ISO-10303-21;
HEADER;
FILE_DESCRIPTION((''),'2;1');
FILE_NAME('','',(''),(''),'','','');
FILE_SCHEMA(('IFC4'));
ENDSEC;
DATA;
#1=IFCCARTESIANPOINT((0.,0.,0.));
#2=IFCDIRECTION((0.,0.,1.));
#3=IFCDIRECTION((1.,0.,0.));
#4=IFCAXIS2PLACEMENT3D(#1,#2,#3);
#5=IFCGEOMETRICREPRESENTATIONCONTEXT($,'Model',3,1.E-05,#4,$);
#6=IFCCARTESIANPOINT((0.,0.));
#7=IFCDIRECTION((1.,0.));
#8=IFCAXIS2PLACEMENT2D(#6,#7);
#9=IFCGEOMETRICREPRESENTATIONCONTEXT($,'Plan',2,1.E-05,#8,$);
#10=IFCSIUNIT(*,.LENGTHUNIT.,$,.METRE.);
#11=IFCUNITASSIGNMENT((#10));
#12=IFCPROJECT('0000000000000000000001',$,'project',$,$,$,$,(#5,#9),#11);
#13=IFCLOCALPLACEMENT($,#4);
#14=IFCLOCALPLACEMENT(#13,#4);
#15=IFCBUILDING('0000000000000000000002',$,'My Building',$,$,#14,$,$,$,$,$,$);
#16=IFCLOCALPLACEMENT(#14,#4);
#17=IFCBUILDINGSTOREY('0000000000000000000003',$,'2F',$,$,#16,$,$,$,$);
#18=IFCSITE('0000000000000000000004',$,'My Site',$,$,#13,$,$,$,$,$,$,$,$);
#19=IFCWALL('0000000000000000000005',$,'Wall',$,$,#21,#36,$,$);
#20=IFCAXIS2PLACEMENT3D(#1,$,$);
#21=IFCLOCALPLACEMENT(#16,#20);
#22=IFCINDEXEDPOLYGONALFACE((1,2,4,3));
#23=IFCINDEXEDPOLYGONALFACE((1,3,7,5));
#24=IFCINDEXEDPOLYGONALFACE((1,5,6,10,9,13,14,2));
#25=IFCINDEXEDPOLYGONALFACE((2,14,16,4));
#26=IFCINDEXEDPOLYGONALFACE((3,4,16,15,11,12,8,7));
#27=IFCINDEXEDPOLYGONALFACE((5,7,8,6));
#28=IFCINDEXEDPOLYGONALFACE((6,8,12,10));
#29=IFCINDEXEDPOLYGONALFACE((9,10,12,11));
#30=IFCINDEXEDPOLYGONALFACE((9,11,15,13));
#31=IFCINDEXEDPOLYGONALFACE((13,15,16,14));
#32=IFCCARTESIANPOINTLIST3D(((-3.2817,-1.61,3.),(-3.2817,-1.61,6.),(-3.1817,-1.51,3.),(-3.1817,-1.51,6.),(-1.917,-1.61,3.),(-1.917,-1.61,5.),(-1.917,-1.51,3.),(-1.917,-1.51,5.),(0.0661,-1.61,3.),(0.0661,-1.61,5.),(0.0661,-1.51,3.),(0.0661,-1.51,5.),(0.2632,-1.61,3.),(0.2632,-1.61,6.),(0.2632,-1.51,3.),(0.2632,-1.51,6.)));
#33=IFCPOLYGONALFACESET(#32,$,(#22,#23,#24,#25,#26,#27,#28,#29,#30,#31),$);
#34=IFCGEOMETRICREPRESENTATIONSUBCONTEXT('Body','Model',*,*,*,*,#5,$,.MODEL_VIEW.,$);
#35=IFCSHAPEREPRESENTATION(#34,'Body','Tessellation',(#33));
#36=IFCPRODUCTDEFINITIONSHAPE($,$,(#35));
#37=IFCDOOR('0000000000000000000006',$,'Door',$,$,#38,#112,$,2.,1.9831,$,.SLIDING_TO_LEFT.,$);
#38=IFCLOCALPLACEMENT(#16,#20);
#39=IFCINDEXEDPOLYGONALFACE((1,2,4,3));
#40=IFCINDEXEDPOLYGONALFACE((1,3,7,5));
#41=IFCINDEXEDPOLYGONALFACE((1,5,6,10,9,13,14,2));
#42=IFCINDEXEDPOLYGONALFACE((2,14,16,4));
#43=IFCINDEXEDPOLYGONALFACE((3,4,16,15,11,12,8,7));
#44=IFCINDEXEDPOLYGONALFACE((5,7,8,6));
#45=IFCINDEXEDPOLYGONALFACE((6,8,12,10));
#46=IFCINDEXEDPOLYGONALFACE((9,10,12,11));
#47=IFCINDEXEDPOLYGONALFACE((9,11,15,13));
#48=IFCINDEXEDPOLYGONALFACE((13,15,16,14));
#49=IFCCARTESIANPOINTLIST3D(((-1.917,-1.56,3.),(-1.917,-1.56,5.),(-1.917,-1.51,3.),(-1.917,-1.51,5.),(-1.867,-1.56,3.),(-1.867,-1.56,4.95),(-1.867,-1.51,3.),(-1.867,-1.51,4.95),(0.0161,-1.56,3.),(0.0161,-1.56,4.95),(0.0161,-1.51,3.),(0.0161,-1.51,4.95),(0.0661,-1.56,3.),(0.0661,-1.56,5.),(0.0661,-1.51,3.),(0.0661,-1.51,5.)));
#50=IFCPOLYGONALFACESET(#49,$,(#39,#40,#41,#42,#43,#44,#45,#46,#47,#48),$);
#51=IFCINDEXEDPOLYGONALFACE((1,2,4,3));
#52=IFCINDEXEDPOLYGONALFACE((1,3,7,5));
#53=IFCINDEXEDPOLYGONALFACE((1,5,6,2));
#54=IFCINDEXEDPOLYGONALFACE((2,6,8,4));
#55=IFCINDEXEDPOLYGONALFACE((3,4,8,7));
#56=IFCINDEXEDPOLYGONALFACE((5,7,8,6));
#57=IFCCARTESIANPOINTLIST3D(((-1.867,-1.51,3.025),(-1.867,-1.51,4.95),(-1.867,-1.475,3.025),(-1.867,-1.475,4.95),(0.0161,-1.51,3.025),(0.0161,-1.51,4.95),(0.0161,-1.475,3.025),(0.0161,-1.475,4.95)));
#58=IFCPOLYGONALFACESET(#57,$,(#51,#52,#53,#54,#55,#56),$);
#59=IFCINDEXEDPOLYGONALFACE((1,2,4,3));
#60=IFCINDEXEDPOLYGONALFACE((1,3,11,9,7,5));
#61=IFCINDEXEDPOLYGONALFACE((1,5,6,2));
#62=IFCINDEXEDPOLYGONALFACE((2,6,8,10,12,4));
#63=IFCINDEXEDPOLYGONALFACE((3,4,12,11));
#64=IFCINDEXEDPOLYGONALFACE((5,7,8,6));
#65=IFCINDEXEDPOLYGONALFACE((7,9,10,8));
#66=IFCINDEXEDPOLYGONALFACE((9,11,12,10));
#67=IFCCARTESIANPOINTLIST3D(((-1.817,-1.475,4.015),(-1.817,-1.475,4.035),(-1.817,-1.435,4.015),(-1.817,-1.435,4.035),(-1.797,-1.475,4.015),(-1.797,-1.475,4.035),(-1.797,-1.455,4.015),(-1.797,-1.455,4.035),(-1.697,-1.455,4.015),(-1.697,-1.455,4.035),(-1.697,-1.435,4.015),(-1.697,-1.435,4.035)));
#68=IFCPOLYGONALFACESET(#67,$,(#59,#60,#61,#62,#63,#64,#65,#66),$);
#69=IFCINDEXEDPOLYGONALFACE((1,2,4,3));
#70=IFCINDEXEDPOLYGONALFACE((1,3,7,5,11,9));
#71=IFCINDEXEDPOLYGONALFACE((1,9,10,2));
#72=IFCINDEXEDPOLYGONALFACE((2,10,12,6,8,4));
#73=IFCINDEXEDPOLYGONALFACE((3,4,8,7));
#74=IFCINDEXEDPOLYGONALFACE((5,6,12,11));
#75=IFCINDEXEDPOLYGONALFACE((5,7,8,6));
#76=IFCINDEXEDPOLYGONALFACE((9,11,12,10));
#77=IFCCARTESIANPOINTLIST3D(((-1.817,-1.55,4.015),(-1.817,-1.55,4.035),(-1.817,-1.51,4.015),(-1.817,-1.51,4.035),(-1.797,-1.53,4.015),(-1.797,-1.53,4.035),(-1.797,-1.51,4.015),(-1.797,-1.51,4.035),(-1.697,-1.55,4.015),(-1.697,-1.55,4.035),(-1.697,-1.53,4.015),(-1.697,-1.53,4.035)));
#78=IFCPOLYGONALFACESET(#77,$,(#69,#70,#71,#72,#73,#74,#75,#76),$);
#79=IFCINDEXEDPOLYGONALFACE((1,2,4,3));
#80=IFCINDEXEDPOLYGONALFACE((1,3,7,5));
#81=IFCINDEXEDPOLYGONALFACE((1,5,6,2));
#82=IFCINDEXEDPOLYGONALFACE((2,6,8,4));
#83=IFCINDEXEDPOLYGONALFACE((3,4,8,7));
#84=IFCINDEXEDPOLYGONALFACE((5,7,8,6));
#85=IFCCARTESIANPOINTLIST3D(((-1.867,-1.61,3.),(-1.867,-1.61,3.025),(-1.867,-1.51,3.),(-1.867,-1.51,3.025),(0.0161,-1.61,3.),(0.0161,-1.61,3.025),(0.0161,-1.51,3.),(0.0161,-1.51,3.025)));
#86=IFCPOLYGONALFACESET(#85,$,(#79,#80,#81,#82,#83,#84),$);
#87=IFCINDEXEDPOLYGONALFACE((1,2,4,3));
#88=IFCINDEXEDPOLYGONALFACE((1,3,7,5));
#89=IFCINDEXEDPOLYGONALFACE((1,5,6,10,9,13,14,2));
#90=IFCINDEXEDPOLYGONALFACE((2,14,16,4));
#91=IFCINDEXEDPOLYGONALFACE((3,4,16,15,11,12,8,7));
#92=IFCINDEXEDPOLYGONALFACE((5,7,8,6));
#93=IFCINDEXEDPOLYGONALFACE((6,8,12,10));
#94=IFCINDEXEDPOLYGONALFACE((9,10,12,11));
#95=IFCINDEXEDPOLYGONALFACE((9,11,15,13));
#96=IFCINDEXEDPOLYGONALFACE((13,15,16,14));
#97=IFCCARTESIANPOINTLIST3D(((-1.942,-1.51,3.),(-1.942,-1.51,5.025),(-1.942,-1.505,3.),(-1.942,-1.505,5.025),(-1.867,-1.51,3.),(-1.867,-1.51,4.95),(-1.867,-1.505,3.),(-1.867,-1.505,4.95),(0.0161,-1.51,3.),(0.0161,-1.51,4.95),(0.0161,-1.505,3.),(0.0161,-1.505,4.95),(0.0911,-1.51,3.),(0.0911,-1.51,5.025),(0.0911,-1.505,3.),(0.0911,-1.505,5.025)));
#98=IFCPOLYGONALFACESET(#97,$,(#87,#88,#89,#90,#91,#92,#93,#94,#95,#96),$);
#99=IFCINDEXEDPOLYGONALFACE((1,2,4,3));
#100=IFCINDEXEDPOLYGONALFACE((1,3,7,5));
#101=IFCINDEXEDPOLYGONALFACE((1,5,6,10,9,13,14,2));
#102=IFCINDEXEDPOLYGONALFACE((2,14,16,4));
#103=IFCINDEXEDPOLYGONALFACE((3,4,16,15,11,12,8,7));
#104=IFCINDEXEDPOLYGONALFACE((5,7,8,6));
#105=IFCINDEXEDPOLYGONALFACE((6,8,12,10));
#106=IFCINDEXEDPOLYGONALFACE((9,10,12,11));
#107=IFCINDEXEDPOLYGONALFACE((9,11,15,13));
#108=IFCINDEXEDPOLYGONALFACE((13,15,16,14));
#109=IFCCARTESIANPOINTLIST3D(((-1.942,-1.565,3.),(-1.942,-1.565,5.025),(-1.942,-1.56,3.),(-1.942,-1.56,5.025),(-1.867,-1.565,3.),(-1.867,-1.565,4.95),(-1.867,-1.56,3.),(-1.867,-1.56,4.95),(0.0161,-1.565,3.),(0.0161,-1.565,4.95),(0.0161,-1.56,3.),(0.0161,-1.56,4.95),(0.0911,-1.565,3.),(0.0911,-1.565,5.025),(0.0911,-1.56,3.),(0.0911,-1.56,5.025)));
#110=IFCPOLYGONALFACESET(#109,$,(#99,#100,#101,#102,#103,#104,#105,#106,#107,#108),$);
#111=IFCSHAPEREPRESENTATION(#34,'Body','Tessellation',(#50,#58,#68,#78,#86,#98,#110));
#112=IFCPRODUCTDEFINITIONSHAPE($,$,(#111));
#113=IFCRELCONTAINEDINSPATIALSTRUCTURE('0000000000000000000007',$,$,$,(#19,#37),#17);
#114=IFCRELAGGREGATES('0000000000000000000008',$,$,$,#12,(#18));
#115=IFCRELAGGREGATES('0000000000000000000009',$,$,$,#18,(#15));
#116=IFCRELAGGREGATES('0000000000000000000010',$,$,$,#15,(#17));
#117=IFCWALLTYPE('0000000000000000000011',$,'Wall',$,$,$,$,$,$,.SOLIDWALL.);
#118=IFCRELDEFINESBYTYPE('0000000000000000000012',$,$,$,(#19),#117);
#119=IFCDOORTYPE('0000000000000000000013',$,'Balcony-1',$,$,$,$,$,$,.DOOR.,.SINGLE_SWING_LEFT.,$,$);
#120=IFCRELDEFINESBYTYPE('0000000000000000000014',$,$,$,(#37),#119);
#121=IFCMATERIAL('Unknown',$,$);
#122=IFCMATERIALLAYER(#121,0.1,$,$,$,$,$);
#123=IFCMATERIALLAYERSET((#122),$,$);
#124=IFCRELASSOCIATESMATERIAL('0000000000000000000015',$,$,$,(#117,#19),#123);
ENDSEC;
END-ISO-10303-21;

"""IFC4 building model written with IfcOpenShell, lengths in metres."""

from ifc_helpers import new_model, entity, si_unit, frame, origin_with_axes, origin_2d_with_axis, place, context, subcontext, project, spatial, line, indexed_curve, outline, extrude, shape, source, transform, mapped, material, layer, layer_set, layer_usage, type_object, type_shapes, element, fill, save


model = new_model("IFC4")

# Units and contexts
model_context = context("Model", 3, precision=1e-05, world=origin_with_axes())
plan_context = context("Plan", 2, precision=1e-05, world=origin_2d_with_axis())
body_context_1 = subcontext(model_context, "Body", "Model", "MODEL_VIEW")
body_context_2 = subcontext(plan_context, "Body", "Plan", "PLAN_VIEW")
ifc_project = project(units=[si_unit("LENGTHUNIT", "METRE")], contexts=[model_context, plan_context])

# Site, building, storey
site_placement = place(None, origin_with_axes())
site = spatial("IfcSite", under=ifc_project, at=site_placement, Name="My Site")
building_placement = place(site_placement, origin_with_axes())
building = spatial("IfcBuilding", under=site, at=building_placement, Name="My Building")
storey_placement = place(building_placement, origin_with_axes())
storey = spatial("IfcBuildingStorey", under=building, at=storey_placement, Name="2F")

# Shared definitions
ifc_material = material(Name="Unknown")
ifc_layer = layer(ifc_material, 0.1)
ifc_layer_set = layer_set([ifc_layer])
wall_type = type_object("IfcWallType", Name="Wall", PredefinedType="SOLIDWALL", material=ifc_layer_set)

# Wall, opening, door
ifc_layer_usage_1 = layer_usage(ifc_layer_set, "AXIS2", "POSITIVE", 0.0)
wall_1_placement = place(storey_placement, frame((-3.2817, -1.61, 3.0), z_axis=(0.0, 0.0, 1.0), x_axis=(1.0, 0.0, 0.0)))
wall_1 = element("IfcWall", 1, at=wall_1_placement, inside=storey, type_object=wall_type, material=ifc_layer_usage_1, Name="Wall", context=body_context_1, shape_type="SweptSolid", body=[
    extrude(outline(indexed_curve([(0.0, 0.0), (0.1, 0.1), (3.5448, 0.1), (3.5448, 0.0)], segments=[line(1, 2, 3, 4, 1)])), origin_with_axes(), (0.0, 0.0, 1.0), 3.0),
])
shared_shape_1 = source(origin_with_axes(), body_context_1, "Body", "SweptSolid", [
    extrude(outline(indexed_curve([(0.0, 0.0), (1.9831, 0.0), (1.9831, 2.0), (0.0, 2.0)], segments=[line(1, 2, 3, 4, 1)])), frame((0.0, -0.6, 0.0), z_axis=(0.0, -1.0, 0.0), x_axis=(1.0, 0.0, 0.0)), (0.0, 0.0, -1.0), 1.2),
])
opening_1_placement = place(wall_1_placement, frame((3.3477, 0.1, 0.0), z_axis=(0.0, 0.0, 1.0), x_axis=(-1.0, 0.0, 0.0)))
opening_1 = element("IfcOpeningElement", 2, at=opening_1_placement, cuts=wall_1, PredefinedType="OPENING", context=body_context_1, shape_type="MappedRepresentation", body=[
    mapped(shared_shape_1, transform((0.0, 0.0, 0.0), x_axis=(1.0, 0.0, 0.0), y_axis=(0.0, 1.0, 0.0), z_axis=(0.0, 0.0, 1.0), scale=1.0)),
])
door_type_1 = type_object("IfcDoorType", Name="Balcony-1", OperationType="SINGLE_SWING_LEFT", PredefinedType="DOOR")
shared_shape_2 = source(origin_with_axes(), body_context_1, "Body", "SweptSolid", [
    extrude(outline(indexed_curve([(0.0, 0.0), (0.0, 2.0), (1.9831, 2.0), (1.9831, 0.0), (1.9331, 0.0), (1.9331, 1.95), (0.05, 1.95), (0.05, 0.0)], segments=[line(1, 2, 3, 4, 5, 6, 7, 8, 1)])), frame((0.0, 0.0, 0.0), z_axis=(0.0, -1.0, 0.0), x_axis=(1.0, 0.0, 0.0)), (0.0, 0.0, -1.0), 0.05),
    extrude(outline(indexed_curve([(0.0, 0.0), (1.8831, 0.0), (1.8831, 0.035), (0.0, 0.035)], segments=[line(1, 2, 3, 4, 1)])), frame((0.05, -0.035, 0.025), z_axis=(0.0, 0.0, 1.0), x_axis=(1.0, 0.0, 0.0)), (0.0, 0.0, 1.0), 1.925),
    extrude(outline(indexed_curve([(0.0, 0.0), (0.0, -0.04), (-0.12, -0.04), (-0.12, -0.02), (-0.02, -0.02), (-0.02, 0.0)], segments=[line(1, 2, 3, 4, 5, 6, 1)])), frame((1.8831, -0.035, 1.015), z_axis=(0.0, 0.0, 1.0), x_axis=(1.0, 0.0, 0.0)), (0.0, 0.0, 1.0), 0.02),
    extrude(outline(indexed_curve([(0.0, 0.0), (0.0, 0.04), (-0.12, 0.04), (-0.12, 0.02), (-0.02, 0.02), (-0.02, 0.0)], segments=[line(1, 2, 3, 4, 5, 6, 1)])), frame((1.8831, 0.0, 1.015), z_axis=(0.0, 0.0, 1.0), x_axis=(1.0, 0.0, 0.0)), (0.0, 0.0, 1.0), 0.02),
    extrude(outline(indexed_curve([(0.0, 0.0), (1.8831, 0.0), (1.8831, 0.1), (0.0, 0.1)], segments=[line(1, 2, 3, 4, 1)])), frame((0.05, 0.0, 0.0), z_axis=(0.0, 0.0, 1.0), x_axis=(1.0, 0.0, 0.0)), (0.0, 0.0, 1.0), 0.025),
    extrude(outline(indexed_curve([(0.0, 0.0), (0.0, 2.025), (2.0331, 2.025), (2.0331, 0.0), (1.9581, 0.0), (1.9581, 1.95), (0.075, 1.95), (0.075, 0.0)], segments=[line(1, 2, 3, 4, 5, 6, 7, 8, 1)])), frame((-0.025, -0.005, 0.0), z_axis=(0.0, -1.0, 0.0), x_axis=(1.0, 0.0, 0.0)), (0.0, 0.0, -1.0), 0.005),
    extrude(outline(indexed_curve([(0.0, 0.0), (0.0, 2.025), (2.0331, 2.025), (2.0331, 0.0), (1.9581, 0.0), (1.9581, 1.95), (0.075, 1.95), (0.075, 0.0)], segments=[line(1, 2, 3, 4, 5, 6, 7, 8, 1)])), frame((-0.025, 0.05, 0.0), z_axis=(0.0, -1.0, 0.0), x_axis=(1.0, 0.0, 0.0)), (0.0, 0.0, -1.0), 0.005),
])
shared_shape_3 = source(origin_with_axes(), body_context_2, "Body", "Curve2D", [
    entity("IfcIndexedPolyCurve", entity("IfcCartesianPointList2D", [[0.0, 0.0], [0.05, 0.0], [0.05, 0.05], [0.0, 0.05]]), [entity("IfcLineIndex", [1, 2, 3, 4, 1])]),
    entity("IfcIndexedPolyCurve", entity("IfcCartesianPointList2D", [[1.9831, 0.0], [1.9331, 0.0], [1.9331, 0.05], [1.9831, 0.05]]), [entity("IfcLineIndex", [1, 2, 3, 4, 1])]),
    entity("IfcIndexedPolyCurve", entity("IfcCartesianPointList2D", [[-0.8915, -0.035], [0.9915, -0.035], [0.9915, 0.0], [-0.8915, 0.0]]), [entity("IfcLineIndex", [1, 2, 3, 4, 1])]),
])
type_shapes(door_type_1, [shared_shape_2, shared_shape_3])
door_1_placement = place(opening_1_placement, frame((0.0, 0.0, 0.0), z_axis=(0.0, 0.0, 1.0), x_axis=(1.0, 0.0, 0.0)))
door_1 = element("IfcDoor", 3, at=door_1_placement, inside=storey, type_object=door_type_1, Name="Door", OperationType="SLIDING_TO_LEFT", OverallHeight=2.0, OverallWidth=1.9831, shapes=[
    shape(body_context_1, "Body", "MappedRepresentation", [mapped(shared_shape_2, transform((0.0, 0.0, 0.0), x_axis=(1.0, 0.0, 0.0), y_axis=(0.0, 1.0, 0.0), z_axis=(0.0, 0.0, 1.0), scale=1.0))]),
    shape(body_context_2, "Body", "MappedRepresentation", [mapped(shared_shape_3, transform((0.0, 0.0, 0.0), x_axis=(1.0, 0.0, 0.0), y_axis=(0.0, 1.0, 0.0), z_axis=(0.0, 0.0, 1.0), scale=1.0))]),
])
fill(opening_1, door_1)

save(model, "model.ifc")
